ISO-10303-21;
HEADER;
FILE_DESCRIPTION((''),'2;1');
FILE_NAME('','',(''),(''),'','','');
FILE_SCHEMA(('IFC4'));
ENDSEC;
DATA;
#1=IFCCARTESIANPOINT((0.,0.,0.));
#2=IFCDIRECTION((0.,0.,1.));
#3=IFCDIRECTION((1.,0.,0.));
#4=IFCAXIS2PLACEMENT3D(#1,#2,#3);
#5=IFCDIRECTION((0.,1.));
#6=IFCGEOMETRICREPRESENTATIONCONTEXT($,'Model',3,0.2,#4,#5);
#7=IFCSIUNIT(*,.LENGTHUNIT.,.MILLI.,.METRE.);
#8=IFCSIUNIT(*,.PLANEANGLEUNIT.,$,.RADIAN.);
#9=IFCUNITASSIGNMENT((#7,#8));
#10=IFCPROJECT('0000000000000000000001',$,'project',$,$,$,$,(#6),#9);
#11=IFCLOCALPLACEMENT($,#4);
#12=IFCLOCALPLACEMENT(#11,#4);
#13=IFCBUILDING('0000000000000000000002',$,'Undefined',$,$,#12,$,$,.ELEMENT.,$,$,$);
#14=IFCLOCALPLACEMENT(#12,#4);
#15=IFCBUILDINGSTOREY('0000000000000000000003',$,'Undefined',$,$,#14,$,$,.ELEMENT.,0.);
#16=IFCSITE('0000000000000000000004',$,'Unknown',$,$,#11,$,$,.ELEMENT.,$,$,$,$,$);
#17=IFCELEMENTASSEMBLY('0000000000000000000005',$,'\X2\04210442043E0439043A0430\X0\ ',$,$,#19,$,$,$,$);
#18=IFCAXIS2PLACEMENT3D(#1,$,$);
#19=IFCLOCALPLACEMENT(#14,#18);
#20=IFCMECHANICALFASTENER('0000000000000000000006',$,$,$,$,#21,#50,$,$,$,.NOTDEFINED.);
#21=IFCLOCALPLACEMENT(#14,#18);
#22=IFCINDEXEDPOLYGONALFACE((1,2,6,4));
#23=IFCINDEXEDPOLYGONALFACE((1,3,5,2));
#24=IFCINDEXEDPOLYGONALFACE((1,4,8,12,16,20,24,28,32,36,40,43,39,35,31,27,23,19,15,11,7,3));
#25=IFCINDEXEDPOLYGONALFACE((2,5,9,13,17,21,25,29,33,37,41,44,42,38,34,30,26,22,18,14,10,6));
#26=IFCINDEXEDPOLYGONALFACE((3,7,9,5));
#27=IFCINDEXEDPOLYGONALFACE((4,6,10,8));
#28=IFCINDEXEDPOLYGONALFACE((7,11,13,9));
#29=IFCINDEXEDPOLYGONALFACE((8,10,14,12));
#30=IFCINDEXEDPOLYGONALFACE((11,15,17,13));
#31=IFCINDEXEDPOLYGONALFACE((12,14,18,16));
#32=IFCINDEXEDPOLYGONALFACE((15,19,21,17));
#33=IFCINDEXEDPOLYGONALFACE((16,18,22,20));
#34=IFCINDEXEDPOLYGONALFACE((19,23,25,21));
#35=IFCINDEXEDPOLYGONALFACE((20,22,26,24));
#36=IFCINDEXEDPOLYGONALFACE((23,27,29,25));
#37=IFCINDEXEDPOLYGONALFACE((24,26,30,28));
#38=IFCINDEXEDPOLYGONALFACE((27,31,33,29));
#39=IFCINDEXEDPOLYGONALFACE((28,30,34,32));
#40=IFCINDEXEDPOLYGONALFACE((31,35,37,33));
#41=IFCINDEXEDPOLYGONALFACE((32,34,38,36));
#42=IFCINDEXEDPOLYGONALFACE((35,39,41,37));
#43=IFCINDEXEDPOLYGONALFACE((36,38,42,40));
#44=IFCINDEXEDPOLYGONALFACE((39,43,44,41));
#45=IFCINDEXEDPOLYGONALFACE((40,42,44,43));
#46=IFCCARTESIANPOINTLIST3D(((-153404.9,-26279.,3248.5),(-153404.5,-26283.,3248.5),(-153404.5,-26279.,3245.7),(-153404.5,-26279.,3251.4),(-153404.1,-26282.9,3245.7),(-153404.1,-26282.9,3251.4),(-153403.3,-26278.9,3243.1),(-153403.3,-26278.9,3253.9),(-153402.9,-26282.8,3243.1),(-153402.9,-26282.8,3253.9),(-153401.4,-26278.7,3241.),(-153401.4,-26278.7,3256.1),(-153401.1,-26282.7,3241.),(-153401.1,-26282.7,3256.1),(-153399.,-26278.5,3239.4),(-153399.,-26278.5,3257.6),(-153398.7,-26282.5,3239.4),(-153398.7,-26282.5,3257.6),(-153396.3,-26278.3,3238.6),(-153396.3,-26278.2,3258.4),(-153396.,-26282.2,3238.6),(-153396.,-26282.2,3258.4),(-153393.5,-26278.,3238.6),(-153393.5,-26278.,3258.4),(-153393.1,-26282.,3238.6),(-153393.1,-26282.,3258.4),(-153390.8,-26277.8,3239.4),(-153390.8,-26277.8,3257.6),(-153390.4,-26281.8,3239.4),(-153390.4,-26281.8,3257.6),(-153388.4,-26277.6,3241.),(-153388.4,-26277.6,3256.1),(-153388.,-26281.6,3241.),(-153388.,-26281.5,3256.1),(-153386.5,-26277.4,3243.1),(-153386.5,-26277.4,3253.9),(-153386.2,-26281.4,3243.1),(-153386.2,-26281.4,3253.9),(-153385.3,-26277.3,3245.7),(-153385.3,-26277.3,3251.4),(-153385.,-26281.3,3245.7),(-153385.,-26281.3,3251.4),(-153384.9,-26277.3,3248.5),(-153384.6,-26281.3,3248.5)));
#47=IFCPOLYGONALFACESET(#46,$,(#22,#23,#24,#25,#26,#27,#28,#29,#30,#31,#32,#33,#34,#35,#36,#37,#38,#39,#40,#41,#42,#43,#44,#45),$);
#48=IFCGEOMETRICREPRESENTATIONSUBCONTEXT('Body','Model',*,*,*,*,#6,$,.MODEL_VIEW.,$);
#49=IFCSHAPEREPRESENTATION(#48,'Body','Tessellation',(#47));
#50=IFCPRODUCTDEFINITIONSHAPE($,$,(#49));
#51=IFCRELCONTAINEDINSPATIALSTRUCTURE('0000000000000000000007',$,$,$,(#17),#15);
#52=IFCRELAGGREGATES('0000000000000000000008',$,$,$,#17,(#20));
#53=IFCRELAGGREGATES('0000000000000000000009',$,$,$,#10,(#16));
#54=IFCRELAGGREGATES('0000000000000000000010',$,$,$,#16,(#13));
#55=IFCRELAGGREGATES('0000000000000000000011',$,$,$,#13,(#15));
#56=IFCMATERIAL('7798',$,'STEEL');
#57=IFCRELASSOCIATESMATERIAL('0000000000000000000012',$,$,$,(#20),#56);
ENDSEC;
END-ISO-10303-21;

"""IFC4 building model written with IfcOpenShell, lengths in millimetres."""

from ifc_helpers import new_model, si_unit, direction, frame, origin_with_axes, place, context, subcontext, project, spatial, arc, indexed_curve, outline, extrude, source, transform, mapped, material, element, aggregate, save


model = new_model("IFC4")

# Units and contexts
model_context = context("Model", 3, precision=0.2, world=origin_with_axes(), true_north=direction((0.0, 1.0)))
body_context = subcontext(model_context, "Body", "Model", "MODEL_VIEW")
ifc_project = project(units=[si_unit("LENGTHUNIT", "METRE", prefix="MILLI"), si_unit("PLANEANGLEUNIT", "RADIAN")], contexts=[model_context])

# Site, building, storey
site_placement = place(None, origin_with_axes())
site = spatial("IfcSite", under=ifc_project, at=site_placement, Name="Unknown", CompositionType="ELEMENT")
building_placement = place(site_placement, origin_with_axes())
building = spatial("IfcBuilding", under=site, at=building_placement, Name="Undefined", CompositionType="ELEMENT")
storey_placement = place(building_placement, origin_with_axes())
storey = spatial("IfcBuildingStorey", under=building, at=storey_placement, Name="Undefined", CompositionType="ELEMENT", Elevation=0.0)

# Element assembly
assembly_1_placement = place(storey_placement, frame((-153388.9, -26231.4, 131.5), z_axis=(-0.086114, 0.996285, 0.0), x_axis=(0.0, 0.0, 1.0)))
assembly_1 = element("IfcElementAssembly", 1, at=assembly_1_placement, inside=storey, Name="Стойка ")

# Mechanical fastener
ifc_material_1 = material(Name="7798", Category="STEEL")
shared_shape_1 = source(origin_with_axes(), body_context, "Body", "SweptSolid", [
    extrude(outline(indexed_curve([(10.0, 0.0), (0.0, 10.0), (-10.0, 0.0), (0.0, -10.0)], segments=[arc(1, 2, 3), arc(3, 4, 1)])), frame((0.0, 0.0, 0.0), z_axis=(0.0, 0.0, -1.0), x_axis=(0.0, 1.0, 0.0)), (0.0, 0.0, 1.0), 4.0),
])
mechanical_fastener_1_placement = place(assembly_1_placement, frame((3117.0, -10.0, -50.0), z_axis=(0.000303, 0.0, -1.0), x_axis=(-1.0, -0.000024, -0.000303)))
mechanical_fastener_1 = element("IfcMechanicalFastener", 2, at=mechanical_fastener_1_placement, material=ifc_material_1, PredefinedType="NOTDEFINED", context=body_context, shape_type="MappedRepresentation", body=[
    mapped(shared_shape_1, transform((0.0, 0.0, 0.0))),
])
aggregate(assembly_1, [mechanical_fastener_1])

save(model, "model.ifc")
